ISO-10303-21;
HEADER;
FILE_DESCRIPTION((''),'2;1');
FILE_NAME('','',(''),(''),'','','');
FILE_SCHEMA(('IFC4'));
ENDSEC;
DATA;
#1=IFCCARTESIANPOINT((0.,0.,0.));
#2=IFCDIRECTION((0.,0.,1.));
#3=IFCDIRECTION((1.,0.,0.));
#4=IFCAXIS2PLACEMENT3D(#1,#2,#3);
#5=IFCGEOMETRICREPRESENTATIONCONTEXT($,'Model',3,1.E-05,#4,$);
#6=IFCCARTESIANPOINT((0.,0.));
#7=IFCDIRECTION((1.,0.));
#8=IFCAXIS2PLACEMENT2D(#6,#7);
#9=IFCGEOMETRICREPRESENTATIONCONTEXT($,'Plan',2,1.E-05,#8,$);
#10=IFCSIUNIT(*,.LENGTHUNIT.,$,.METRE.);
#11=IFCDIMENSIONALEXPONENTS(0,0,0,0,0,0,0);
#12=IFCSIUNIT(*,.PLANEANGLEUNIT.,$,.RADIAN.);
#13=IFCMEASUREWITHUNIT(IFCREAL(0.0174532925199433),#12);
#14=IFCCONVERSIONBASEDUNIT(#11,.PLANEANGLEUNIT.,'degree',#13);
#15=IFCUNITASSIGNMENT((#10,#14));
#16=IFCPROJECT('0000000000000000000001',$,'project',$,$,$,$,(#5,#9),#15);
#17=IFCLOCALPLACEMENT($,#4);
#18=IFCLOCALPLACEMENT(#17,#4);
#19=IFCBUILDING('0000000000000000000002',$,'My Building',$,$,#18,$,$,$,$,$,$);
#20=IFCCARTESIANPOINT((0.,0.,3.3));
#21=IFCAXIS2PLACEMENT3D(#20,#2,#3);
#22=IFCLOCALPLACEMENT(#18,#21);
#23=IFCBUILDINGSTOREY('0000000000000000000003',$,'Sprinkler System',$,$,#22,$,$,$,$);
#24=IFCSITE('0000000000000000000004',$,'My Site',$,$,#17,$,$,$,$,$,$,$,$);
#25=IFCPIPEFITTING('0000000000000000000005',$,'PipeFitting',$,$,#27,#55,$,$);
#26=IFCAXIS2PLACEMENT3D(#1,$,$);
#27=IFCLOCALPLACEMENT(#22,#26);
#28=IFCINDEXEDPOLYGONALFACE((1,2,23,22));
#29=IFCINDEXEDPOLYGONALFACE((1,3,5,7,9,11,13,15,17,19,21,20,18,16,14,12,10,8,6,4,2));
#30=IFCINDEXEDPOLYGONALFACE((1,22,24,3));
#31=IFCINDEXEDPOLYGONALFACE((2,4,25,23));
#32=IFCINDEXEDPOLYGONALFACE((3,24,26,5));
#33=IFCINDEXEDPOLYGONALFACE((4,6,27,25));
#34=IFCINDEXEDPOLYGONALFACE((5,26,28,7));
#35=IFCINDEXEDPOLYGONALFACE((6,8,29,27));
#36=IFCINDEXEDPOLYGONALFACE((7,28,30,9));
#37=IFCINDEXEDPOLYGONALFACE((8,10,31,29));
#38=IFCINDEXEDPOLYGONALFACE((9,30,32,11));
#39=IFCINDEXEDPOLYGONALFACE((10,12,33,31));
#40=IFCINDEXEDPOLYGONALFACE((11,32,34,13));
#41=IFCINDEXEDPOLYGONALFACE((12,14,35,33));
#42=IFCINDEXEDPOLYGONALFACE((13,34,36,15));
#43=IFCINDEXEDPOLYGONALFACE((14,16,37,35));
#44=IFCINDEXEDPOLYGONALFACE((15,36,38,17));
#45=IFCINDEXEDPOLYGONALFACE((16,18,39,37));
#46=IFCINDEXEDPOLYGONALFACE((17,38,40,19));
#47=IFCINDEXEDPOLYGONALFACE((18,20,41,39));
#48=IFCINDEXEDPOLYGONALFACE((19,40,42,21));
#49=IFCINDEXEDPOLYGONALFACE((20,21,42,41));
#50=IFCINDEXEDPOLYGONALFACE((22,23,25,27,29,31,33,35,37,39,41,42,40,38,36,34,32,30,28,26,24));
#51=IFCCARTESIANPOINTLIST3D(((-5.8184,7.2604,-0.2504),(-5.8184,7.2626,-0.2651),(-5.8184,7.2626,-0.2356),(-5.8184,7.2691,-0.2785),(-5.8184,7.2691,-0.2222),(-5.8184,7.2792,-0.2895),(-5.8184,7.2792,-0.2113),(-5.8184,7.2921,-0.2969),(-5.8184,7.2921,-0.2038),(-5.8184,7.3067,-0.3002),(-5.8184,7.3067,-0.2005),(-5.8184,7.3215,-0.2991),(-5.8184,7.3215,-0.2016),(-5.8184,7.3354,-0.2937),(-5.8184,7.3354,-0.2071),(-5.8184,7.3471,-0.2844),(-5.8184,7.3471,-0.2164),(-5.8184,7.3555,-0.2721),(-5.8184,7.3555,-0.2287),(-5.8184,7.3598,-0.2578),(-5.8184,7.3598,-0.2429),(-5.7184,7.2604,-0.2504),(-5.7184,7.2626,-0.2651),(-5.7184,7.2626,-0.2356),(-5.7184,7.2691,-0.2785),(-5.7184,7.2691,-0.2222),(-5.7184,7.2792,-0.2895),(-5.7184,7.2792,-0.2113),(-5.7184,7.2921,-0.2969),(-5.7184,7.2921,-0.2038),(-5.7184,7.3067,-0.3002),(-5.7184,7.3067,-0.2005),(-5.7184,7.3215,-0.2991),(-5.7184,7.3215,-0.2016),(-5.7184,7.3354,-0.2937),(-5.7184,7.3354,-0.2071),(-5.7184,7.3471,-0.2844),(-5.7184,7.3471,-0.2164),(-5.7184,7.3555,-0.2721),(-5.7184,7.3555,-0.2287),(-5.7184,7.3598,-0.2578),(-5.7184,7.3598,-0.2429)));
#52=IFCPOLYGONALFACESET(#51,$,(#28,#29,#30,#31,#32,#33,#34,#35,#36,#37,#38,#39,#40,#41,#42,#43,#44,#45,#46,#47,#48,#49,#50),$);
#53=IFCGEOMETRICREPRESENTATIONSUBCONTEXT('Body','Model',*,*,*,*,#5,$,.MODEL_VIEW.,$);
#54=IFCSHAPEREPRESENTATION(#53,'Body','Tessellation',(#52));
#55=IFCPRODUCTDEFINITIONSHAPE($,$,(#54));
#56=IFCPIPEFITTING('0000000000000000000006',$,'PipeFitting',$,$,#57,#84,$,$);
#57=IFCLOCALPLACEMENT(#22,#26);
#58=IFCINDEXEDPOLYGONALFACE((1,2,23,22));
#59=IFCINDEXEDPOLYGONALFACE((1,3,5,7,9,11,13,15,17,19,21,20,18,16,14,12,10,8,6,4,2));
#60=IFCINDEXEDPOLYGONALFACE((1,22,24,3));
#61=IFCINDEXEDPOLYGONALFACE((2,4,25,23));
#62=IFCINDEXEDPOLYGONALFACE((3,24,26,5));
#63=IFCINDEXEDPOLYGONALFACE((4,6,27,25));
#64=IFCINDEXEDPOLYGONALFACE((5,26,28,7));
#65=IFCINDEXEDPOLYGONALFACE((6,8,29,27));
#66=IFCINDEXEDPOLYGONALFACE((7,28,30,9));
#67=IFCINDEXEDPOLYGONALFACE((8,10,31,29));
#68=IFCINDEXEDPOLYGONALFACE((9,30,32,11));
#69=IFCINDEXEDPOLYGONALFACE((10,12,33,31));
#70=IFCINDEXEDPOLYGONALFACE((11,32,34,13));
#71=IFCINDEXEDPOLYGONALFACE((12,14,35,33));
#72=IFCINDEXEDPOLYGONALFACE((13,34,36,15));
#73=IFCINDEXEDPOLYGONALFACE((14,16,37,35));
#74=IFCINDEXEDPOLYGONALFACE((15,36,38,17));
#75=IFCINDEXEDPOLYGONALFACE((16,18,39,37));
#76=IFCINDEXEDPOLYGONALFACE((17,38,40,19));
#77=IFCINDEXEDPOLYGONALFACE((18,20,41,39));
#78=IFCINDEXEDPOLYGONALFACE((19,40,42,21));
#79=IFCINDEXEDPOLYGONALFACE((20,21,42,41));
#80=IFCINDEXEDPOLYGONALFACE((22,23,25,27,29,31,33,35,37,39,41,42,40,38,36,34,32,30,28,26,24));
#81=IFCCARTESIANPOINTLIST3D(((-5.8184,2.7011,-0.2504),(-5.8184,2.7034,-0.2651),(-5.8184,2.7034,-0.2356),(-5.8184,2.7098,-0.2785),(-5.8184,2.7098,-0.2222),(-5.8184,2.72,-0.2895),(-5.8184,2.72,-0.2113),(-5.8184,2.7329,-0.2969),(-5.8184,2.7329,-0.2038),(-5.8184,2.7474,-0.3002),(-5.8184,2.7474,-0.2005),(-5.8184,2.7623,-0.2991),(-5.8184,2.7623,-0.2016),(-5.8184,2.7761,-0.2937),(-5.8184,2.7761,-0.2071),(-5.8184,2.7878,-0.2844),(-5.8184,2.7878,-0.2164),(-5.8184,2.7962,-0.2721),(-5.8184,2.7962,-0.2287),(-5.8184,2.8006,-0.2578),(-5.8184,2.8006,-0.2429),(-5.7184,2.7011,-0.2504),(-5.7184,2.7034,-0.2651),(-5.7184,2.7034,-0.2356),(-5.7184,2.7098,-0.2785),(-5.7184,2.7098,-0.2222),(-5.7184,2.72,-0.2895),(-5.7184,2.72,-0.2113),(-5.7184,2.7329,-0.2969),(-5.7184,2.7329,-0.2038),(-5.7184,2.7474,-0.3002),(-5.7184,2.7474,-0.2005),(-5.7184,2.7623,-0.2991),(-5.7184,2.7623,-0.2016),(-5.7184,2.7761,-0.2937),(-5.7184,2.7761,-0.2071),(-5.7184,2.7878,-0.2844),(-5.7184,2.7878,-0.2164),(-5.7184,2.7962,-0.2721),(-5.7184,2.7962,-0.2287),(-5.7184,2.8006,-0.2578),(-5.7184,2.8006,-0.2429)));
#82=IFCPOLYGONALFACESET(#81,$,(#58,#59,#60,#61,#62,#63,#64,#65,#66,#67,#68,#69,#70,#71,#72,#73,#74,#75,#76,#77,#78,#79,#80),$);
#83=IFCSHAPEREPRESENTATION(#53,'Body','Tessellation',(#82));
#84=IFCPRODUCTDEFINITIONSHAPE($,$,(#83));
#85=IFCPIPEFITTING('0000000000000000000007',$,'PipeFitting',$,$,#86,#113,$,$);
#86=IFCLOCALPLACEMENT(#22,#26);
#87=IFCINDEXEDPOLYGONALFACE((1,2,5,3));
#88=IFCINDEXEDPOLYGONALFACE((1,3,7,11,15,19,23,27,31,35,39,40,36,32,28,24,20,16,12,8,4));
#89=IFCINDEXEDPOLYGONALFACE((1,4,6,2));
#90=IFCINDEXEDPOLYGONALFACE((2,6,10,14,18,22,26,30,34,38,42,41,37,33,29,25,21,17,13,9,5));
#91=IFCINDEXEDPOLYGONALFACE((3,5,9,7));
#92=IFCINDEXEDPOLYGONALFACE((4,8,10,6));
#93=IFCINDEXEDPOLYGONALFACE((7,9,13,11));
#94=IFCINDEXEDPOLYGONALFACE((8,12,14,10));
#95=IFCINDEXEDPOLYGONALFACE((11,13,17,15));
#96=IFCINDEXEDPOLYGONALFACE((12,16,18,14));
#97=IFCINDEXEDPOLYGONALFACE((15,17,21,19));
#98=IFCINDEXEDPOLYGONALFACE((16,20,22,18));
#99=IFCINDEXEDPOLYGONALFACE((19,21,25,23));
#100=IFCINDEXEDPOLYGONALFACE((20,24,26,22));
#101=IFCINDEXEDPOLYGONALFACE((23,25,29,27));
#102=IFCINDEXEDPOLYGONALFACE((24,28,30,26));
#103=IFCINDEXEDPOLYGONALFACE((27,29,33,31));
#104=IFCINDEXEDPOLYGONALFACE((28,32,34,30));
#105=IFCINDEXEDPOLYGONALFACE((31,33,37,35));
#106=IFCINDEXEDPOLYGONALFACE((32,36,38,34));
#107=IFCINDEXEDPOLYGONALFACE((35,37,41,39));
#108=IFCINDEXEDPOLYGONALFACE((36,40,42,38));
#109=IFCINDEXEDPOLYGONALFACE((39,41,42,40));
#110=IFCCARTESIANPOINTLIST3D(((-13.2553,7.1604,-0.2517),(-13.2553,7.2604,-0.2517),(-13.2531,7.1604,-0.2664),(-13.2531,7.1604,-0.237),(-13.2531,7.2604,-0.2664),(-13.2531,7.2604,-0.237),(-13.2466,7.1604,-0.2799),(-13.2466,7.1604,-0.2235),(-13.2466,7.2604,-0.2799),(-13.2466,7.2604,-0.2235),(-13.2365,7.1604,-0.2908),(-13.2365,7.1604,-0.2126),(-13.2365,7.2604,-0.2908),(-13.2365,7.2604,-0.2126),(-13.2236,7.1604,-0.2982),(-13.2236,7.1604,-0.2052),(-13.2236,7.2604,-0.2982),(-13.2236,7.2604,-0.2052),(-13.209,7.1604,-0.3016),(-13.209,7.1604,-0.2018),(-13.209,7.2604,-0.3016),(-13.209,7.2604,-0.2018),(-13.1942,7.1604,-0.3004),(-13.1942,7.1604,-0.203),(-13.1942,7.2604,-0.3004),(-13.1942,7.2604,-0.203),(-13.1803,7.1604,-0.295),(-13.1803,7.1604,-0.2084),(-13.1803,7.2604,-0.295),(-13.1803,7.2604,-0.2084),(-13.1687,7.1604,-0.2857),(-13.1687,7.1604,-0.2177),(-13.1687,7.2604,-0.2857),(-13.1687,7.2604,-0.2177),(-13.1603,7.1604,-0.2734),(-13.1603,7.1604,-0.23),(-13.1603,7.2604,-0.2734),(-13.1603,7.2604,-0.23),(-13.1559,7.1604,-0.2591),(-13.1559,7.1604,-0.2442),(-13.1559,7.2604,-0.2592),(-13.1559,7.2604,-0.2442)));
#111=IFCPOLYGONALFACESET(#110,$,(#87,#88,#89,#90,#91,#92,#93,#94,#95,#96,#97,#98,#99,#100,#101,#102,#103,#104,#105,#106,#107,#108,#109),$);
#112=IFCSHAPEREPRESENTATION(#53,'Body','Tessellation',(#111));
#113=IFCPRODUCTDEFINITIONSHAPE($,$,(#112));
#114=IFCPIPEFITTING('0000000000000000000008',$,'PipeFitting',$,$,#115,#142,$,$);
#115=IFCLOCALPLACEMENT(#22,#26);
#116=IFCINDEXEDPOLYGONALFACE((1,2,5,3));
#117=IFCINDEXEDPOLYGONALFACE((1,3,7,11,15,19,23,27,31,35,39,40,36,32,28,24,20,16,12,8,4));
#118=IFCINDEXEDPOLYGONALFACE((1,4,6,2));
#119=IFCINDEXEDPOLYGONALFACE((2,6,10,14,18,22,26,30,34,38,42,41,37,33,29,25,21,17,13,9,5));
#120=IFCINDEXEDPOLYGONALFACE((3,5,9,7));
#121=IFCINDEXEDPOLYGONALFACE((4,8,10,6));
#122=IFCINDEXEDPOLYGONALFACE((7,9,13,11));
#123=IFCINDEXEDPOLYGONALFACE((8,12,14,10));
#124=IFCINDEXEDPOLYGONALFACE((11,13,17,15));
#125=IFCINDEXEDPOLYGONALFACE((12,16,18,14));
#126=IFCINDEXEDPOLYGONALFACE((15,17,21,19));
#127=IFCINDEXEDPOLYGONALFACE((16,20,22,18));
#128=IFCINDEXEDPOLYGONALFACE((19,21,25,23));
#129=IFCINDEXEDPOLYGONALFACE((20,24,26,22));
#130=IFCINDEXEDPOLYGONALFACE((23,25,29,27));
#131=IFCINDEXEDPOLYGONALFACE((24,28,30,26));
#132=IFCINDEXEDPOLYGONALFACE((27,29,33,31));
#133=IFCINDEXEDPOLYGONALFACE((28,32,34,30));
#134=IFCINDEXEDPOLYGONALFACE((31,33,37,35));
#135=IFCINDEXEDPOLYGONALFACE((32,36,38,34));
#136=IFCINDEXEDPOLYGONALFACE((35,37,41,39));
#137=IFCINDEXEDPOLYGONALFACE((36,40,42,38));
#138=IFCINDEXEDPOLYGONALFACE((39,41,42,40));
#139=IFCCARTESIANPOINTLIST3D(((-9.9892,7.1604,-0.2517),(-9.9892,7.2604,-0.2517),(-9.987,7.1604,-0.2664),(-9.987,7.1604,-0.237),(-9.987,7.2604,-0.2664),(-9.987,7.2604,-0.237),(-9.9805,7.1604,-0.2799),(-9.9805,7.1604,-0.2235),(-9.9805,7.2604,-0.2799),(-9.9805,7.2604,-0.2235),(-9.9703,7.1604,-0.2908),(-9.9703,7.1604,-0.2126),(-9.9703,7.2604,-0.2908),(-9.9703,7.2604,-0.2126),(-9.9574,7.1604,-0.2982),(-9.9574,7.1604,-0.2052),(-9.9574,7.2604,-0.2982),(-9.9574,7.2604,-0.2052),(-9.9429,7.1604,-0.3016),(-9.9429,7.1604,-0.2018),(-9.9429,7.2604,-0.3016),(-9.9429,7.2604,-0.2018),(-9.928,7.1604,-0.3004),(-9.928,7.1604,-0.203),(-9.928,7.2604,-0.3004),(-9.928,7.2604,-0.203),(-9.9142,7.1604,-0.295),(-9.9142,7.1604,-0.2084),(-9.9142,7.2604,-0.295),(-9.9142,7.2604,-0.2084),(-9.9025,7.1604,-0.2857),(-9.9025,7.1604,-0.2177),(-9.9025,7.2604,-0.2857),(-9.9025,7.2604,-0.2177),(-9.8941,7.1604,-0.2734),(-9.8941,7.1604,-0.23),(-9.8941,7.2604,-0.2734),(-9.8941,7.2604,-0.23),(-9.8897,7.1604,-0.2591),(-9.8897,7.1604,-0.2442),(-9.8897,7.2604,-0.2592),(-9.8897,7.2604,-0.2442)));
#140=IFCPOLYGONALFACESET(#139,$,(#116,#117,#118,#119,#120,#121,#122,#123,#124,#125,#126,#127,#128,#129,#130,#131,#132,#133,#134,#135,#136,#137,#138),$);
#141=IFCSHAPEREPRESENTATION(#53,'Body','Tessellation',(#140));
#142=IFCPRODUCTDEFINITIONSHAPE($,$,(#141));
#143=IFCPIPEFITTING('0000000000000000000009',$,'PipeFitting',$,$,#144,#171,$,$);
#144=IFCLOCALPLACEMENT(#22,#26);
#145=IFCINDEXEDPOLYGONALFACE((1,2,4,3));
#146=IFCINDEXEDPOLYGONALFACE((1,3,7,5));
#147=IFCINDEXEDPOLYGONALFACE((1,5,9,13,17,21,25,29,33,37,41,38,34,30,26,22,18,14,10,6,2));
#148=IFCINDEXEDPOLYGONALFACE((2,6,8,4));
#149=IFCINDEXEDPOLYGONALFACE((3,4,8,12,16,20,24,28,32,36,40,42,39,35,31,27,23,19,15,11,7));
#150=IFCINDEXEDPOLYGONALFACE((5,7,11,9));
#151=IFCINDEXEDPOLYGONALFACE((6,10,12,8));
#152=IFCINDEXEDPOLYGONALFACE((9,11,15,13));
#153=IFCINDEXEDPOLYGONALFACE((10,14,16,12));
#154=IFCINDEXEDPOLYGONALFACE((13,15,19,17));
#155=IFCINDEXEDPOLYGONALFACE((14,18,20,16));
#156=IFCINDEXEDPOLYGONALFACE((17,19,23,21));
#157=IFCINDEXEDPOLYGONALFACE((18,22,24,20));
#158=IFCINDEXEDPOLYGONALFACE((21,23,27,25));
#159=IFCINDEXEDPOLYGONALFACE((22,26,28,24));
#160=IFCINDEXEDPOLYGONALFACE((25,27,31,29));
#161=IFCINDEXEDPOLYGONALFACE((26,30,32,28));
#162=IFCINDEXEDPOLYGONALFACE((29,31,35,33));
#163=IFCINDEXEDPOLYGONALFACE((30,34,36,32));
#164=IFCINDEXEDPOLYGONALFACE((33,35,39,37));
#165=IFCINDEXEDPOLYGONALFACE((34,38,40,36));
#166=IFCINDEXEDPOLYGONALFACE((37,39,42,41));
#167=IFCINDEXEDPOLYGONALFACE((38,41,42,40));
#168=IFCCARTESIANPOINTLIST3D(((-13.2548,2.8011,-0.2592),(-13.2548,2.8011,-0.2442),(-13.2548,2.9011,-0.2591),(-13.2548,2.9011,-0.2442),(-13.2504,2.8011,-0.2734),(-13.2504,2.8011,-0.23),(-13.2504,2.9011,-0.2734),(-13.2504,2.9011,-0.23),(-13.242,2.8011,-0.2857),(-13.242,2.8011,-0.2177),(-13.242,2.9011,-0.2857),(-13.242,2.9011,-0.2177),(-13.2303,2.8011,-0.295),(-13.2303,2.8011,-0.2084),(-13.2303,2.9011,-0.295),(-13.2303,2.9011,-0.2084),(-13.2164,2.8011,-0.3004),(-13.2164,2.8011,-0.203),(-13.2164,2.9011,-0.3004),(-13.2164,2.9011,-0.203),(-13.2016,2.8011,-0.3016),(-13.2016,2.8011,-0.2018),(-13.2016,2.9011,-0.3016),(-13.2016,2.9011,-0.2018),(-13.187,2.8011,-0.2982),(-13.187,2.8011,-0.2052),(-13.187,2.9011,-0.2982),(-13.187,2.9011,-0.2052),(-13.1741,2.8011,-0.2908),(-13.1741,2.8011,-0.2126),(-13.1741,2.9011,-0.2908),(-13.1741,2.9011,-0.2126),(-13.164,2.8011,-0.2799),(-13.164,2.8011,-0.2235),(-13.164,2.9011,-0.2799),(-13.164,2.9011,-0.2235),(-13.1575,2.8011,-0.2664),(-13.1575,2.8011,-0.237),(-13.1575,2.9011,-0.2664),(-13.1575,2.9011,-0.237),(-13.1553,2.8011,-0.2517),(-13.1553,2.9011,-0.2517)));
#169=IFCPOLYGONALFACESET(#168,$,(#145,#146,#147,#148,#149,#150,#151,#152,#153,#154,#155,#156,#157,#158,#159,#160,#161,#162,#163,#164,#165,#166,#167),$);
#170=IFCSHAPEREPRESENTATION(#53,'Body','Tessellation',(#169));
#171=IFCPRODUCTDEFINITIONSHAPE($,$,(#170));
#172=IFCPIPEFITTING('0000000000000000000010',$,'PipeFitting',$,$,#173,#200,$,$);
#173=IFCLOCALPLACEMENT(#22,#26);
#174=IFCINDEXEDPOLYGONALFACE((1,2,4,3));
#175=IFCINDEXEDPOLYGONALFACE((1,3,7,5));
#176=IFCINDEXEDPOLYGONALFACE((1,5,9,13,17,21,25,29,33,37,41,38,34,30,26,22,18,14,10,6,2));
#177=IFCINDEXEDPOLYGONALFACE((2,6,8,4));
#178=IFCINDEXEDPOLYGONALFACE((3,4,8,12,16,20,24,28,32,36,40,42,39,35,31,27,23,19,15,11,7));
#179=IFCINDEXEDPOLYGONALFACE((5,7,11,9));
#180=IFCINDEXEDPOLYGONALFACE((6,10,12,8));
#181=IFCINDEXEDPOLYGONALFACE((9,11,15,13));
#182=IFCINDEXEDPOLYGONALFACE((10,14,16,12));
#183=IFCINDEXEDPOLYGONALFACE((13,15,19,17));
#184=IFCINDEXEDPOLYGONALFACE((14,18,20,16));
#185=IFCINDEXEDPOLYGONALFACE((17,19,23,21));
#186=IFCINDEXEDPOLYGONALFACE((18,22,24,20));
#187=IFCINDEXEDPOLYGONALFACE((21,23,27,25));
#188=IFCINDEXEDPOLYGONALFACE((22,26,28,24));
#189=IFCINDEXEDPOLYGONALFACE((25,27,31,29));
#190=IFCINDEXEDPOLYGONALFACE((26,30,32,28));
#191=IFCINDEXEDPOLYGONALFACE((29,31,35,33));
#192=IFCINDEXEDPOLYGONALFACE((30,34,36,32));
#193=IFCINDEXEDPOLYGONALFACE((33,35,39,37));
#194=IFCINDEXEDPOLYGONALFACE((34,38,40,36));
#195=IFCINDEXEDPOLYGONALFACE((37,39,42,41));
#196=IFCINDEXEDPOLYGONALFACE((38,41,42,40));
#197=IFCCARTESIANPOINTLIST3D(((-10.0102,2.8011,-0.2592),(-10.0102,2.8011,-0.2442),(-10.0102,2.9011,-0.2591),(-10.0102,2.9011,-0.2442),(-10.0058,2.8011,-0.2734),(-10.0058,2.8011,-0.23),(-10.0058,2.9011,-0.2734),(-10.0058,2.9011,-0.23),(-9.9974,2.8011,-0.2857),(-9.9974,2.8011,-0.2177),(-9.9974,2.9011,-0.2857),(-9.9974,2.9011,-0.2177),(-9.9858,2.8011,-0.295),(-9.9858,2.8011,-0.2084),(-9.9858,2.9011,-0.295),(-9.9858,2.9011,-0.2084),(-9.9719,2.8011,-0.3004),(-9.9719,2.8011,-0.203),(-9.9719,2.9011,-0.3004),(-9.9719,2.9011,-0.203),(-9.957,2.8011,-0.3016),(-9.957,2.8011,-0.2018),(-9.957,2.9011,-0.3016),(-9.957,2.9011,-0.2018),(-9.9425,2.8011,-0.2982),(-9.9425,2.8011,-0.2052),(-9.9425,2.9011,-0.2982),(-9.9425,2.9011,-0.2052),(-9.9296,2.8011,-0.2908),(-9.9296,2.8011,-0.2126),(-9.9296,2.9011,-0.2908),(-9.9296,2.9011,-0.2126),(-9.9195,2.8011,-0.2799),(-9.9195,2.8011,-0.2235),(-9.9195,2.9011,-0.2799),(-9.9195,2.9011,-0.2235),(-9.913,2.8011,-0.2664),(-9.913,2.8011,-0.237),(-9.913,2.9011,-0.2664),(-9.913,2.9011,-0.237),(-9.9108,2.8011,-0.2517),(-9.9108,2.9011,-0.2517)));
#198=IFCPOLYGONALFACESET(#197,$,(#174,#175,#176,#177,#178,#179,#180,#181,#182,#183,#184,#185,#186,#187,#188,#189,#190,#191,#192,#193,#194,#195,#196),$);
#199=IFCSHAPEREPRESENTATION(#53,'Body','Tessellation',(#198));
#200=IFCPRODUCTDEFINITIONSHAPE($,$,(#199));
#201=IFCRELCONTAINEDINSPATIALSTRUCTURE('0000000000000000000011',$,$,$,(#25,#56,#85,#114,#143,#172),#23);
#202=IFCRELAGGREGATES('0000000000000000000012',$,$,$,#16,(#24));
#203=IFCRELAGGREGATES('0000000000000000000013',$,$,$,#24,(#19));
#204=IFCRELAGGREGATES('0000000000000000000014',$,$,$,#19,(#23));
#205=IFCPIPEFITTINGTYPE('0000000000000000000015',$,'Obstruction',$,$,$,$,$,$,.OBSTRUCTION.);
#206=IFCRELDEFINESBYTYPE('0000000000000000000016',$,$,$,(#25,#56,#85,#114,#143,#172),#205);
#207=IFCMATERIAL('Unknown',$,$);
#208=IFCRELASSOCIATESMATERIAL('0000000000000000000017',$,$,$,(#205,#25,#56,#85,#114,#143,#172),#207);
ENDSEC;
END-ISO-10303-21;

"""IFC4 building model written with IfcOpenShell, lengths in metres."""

from ifc_helpers import new_model, entity, si_unit, converted_unit, frame, origin_with_axes, origin_2d_with_axis, place, context, subcontext, project, spatial, circle, extrude, material, material_profile, profile_set, profile_usage, type_object, element, save


model = new_model("IFC4")

# Units and contexts
model_context = context("Model", 3, precision=1e-05, world=origin_with_axes())
plan_context = context("Plan", 2, precision=1e-05, world=origin_2d_with_axis())
body_context = subcontext(model_context, "Body", "Model", "MODEL_VIEW")
ifc_project = project(units=[si_unit("LENGTHUNIT", "METRE"), converted_unit("PLANEANGLEUNIT", "degree", entity("IfcReal", 0.0174532925199433), si_unit("PLANEANGLEUNIT", "RADIAN"), dimensions=[0, 0, 0, 0, 0, 0, 0])], contexts=[model_context, plan_context])

# Site, building, storey
site_placement = place(None, origin_with_axes())
site = spatial("IfcSite", under=ifc_project, at=site_placement, Name="My Site")
building_placement = place(site_placement, origin_with_axes())
building = spatial("IfcBuilding", under=site, at=building_placement, Name="My Building")
storey_placement = place(building_placement, frame((0.0, 0.0, 3.3), z_axis=(0.0, 0.0, 1.0), x_axis=(1.0, 0.0, 0.0)))
storey = spatial("IfcBuildingStorey", under=building, at=storey_placement, Name="Sprinkler System")

# Shared definitions
ifc_material = material(Name="Unknown")

# Pipe fittings
ifc_material_profile_1 = material_profile(ifc_material, circle(Radius=0.05))
ifc_profile_set_1 = profile_set([ifc_material_profile_1])
pipe_fitting_type_1 = type_object("IfcPipeFittingType", Name="Obstruction", PredefinedType="OBSTRUCTION", material=ifc_profile_set_1)
ifc_profile_usage_1 = profile_usage(ifc_profile_set_1, cardinal=5)
pipe_fitting_1_placement = place(storey_placement, frame((-5.7184, 7.3104, -0.2504), z_axis=(-1.0, 0.0, 0.0), x_axis=(0.0, -1.0, 0.0)))
element("IfcPipeFitting", 1, at=pipe_fitting_1_placement, inside=storey, type_object=pipe_fitting_type_1, material=ifc_profile_usage_1, Name="PipeFitting", context=body_context, shape_type="SweptSolid", body=[
    extrude(circle(Radius=0.05), origin_with_axes(), (0.0, 0.0, 1.0), 0.1),
])
ifc_profile_usage_2 = profile_usage(ifc_profile_set_1, cardinal=5)
pipe_fitting_2_placement = place(storey_placement, frame((-5.7184, 2.7511, -0.2504), z_axis=(-1.0, 0.0, 0.0), x_axis=(0.0, -1.0, 0.0)))
element("IfcPipeFitting", 2, at=pipe_fitting_2_placement, inside=storey, type_object=pipe_fitting_type_1, material=ifc_profile_usage_2, Name="PipeFitting", context=body_context, shape_type="SweptSolid", body=[
    extrude(circle(Radius=0.05), origin_with_axes(), (0.0, 0.0, 1.0), 0.1),
])
ifc_profile_usage_3 = profile_usage(ifc_profile_set_1, cardinal=5)
pipe_fitting_3_placement = place(storey_placement, frame((-13.2053, 7.1604, -0.2517), z_axis=(0.0, 1.0, -0.000012), x_axis=(-1.0, 0.0, 0.0)))
element("IfcPipeFitting", 3, at=pipe_fitting_3_placement, inside=storey, type_object=pipe_fitting_type_1, material=ifc_profile_usage_3, Name="PipeFitting", context=body_context, shape_type="SweptSolid", body=[
    extrude(circle(Radius=0.05), origin_with_axes(), (0.0, 0.0, 1.0), 0.1),
])
ifc_profile_usage_4 = profile_usage(ifc_profile_set_1, cardinal=5)
pipe_fitting_4_placement = place(storey_placement, frame((-9.9392, 7.1604, -0.2517), z_axis=(0.0, 1.0, -0.000012), x_axis=(-1.0, 0.0, 0.0)))
element("IfcPipeFitting", 4, at=pipe_fitting_4_placement, inside=storey, type_object=pipe_fitting_type_1, material=ifc_profile_usage_4, Name="PipeFitting", context=body_context, shape_type="SweptSolid", body=[
    extrude(circle(Radius=0.05), origin_with_axes(), (0.0, 0.0, 1.0), 0.1),
])
ifc_profile_usage_5 = profile_usage(ifc_profile_set_1, cardinal=5)
pipe_fitting_5_placement = place(storey_placement, frame((-13.2053, 2.9011, -0.2517), z_axis=(-0.000001, -1.0, -0.000012), x_axis=(1.0, -0.000001, 0.0)))
element("IfcPipeFitting", 5, at=pipe_fitting_5_placement, inside=storey, type_object=pipe_fitting_type_1, material=ifc_profile_usage_5, Name="PipeFitting", context=body_context, shape_type="SweptSolid", body=[
    extrude(circle(Radius=0.05), origin_with_axes(), (0.0, 0.0, 1.0), 0.1),
])
ifc_profile_usage_6 = profile_usage(ifc_profile_set_1, cardinal=5)
pipe_fitting_6_placement = place(storey_placement, frame((-9.9608, 2.9011, -0.2517), z_axis=(-0.000001, -1.0, -0.000012), x_axis=(1.0, -0.000001, 0.0)))
element("IfcPipeFitting", 6, at=pipe_fitting_6_placement, inside=storey, type_object=pipe_fitting_type_1, material=ifc_profile_usage_6, Name="PipeFitting", context=body_context, shape_type="SweptSolid", body=[
    extrude(circle(Radius=0.05), origin_with_axes(), (0.0, 0.0, 1.0), 0.1),
])

save(model, "model.ifc")
